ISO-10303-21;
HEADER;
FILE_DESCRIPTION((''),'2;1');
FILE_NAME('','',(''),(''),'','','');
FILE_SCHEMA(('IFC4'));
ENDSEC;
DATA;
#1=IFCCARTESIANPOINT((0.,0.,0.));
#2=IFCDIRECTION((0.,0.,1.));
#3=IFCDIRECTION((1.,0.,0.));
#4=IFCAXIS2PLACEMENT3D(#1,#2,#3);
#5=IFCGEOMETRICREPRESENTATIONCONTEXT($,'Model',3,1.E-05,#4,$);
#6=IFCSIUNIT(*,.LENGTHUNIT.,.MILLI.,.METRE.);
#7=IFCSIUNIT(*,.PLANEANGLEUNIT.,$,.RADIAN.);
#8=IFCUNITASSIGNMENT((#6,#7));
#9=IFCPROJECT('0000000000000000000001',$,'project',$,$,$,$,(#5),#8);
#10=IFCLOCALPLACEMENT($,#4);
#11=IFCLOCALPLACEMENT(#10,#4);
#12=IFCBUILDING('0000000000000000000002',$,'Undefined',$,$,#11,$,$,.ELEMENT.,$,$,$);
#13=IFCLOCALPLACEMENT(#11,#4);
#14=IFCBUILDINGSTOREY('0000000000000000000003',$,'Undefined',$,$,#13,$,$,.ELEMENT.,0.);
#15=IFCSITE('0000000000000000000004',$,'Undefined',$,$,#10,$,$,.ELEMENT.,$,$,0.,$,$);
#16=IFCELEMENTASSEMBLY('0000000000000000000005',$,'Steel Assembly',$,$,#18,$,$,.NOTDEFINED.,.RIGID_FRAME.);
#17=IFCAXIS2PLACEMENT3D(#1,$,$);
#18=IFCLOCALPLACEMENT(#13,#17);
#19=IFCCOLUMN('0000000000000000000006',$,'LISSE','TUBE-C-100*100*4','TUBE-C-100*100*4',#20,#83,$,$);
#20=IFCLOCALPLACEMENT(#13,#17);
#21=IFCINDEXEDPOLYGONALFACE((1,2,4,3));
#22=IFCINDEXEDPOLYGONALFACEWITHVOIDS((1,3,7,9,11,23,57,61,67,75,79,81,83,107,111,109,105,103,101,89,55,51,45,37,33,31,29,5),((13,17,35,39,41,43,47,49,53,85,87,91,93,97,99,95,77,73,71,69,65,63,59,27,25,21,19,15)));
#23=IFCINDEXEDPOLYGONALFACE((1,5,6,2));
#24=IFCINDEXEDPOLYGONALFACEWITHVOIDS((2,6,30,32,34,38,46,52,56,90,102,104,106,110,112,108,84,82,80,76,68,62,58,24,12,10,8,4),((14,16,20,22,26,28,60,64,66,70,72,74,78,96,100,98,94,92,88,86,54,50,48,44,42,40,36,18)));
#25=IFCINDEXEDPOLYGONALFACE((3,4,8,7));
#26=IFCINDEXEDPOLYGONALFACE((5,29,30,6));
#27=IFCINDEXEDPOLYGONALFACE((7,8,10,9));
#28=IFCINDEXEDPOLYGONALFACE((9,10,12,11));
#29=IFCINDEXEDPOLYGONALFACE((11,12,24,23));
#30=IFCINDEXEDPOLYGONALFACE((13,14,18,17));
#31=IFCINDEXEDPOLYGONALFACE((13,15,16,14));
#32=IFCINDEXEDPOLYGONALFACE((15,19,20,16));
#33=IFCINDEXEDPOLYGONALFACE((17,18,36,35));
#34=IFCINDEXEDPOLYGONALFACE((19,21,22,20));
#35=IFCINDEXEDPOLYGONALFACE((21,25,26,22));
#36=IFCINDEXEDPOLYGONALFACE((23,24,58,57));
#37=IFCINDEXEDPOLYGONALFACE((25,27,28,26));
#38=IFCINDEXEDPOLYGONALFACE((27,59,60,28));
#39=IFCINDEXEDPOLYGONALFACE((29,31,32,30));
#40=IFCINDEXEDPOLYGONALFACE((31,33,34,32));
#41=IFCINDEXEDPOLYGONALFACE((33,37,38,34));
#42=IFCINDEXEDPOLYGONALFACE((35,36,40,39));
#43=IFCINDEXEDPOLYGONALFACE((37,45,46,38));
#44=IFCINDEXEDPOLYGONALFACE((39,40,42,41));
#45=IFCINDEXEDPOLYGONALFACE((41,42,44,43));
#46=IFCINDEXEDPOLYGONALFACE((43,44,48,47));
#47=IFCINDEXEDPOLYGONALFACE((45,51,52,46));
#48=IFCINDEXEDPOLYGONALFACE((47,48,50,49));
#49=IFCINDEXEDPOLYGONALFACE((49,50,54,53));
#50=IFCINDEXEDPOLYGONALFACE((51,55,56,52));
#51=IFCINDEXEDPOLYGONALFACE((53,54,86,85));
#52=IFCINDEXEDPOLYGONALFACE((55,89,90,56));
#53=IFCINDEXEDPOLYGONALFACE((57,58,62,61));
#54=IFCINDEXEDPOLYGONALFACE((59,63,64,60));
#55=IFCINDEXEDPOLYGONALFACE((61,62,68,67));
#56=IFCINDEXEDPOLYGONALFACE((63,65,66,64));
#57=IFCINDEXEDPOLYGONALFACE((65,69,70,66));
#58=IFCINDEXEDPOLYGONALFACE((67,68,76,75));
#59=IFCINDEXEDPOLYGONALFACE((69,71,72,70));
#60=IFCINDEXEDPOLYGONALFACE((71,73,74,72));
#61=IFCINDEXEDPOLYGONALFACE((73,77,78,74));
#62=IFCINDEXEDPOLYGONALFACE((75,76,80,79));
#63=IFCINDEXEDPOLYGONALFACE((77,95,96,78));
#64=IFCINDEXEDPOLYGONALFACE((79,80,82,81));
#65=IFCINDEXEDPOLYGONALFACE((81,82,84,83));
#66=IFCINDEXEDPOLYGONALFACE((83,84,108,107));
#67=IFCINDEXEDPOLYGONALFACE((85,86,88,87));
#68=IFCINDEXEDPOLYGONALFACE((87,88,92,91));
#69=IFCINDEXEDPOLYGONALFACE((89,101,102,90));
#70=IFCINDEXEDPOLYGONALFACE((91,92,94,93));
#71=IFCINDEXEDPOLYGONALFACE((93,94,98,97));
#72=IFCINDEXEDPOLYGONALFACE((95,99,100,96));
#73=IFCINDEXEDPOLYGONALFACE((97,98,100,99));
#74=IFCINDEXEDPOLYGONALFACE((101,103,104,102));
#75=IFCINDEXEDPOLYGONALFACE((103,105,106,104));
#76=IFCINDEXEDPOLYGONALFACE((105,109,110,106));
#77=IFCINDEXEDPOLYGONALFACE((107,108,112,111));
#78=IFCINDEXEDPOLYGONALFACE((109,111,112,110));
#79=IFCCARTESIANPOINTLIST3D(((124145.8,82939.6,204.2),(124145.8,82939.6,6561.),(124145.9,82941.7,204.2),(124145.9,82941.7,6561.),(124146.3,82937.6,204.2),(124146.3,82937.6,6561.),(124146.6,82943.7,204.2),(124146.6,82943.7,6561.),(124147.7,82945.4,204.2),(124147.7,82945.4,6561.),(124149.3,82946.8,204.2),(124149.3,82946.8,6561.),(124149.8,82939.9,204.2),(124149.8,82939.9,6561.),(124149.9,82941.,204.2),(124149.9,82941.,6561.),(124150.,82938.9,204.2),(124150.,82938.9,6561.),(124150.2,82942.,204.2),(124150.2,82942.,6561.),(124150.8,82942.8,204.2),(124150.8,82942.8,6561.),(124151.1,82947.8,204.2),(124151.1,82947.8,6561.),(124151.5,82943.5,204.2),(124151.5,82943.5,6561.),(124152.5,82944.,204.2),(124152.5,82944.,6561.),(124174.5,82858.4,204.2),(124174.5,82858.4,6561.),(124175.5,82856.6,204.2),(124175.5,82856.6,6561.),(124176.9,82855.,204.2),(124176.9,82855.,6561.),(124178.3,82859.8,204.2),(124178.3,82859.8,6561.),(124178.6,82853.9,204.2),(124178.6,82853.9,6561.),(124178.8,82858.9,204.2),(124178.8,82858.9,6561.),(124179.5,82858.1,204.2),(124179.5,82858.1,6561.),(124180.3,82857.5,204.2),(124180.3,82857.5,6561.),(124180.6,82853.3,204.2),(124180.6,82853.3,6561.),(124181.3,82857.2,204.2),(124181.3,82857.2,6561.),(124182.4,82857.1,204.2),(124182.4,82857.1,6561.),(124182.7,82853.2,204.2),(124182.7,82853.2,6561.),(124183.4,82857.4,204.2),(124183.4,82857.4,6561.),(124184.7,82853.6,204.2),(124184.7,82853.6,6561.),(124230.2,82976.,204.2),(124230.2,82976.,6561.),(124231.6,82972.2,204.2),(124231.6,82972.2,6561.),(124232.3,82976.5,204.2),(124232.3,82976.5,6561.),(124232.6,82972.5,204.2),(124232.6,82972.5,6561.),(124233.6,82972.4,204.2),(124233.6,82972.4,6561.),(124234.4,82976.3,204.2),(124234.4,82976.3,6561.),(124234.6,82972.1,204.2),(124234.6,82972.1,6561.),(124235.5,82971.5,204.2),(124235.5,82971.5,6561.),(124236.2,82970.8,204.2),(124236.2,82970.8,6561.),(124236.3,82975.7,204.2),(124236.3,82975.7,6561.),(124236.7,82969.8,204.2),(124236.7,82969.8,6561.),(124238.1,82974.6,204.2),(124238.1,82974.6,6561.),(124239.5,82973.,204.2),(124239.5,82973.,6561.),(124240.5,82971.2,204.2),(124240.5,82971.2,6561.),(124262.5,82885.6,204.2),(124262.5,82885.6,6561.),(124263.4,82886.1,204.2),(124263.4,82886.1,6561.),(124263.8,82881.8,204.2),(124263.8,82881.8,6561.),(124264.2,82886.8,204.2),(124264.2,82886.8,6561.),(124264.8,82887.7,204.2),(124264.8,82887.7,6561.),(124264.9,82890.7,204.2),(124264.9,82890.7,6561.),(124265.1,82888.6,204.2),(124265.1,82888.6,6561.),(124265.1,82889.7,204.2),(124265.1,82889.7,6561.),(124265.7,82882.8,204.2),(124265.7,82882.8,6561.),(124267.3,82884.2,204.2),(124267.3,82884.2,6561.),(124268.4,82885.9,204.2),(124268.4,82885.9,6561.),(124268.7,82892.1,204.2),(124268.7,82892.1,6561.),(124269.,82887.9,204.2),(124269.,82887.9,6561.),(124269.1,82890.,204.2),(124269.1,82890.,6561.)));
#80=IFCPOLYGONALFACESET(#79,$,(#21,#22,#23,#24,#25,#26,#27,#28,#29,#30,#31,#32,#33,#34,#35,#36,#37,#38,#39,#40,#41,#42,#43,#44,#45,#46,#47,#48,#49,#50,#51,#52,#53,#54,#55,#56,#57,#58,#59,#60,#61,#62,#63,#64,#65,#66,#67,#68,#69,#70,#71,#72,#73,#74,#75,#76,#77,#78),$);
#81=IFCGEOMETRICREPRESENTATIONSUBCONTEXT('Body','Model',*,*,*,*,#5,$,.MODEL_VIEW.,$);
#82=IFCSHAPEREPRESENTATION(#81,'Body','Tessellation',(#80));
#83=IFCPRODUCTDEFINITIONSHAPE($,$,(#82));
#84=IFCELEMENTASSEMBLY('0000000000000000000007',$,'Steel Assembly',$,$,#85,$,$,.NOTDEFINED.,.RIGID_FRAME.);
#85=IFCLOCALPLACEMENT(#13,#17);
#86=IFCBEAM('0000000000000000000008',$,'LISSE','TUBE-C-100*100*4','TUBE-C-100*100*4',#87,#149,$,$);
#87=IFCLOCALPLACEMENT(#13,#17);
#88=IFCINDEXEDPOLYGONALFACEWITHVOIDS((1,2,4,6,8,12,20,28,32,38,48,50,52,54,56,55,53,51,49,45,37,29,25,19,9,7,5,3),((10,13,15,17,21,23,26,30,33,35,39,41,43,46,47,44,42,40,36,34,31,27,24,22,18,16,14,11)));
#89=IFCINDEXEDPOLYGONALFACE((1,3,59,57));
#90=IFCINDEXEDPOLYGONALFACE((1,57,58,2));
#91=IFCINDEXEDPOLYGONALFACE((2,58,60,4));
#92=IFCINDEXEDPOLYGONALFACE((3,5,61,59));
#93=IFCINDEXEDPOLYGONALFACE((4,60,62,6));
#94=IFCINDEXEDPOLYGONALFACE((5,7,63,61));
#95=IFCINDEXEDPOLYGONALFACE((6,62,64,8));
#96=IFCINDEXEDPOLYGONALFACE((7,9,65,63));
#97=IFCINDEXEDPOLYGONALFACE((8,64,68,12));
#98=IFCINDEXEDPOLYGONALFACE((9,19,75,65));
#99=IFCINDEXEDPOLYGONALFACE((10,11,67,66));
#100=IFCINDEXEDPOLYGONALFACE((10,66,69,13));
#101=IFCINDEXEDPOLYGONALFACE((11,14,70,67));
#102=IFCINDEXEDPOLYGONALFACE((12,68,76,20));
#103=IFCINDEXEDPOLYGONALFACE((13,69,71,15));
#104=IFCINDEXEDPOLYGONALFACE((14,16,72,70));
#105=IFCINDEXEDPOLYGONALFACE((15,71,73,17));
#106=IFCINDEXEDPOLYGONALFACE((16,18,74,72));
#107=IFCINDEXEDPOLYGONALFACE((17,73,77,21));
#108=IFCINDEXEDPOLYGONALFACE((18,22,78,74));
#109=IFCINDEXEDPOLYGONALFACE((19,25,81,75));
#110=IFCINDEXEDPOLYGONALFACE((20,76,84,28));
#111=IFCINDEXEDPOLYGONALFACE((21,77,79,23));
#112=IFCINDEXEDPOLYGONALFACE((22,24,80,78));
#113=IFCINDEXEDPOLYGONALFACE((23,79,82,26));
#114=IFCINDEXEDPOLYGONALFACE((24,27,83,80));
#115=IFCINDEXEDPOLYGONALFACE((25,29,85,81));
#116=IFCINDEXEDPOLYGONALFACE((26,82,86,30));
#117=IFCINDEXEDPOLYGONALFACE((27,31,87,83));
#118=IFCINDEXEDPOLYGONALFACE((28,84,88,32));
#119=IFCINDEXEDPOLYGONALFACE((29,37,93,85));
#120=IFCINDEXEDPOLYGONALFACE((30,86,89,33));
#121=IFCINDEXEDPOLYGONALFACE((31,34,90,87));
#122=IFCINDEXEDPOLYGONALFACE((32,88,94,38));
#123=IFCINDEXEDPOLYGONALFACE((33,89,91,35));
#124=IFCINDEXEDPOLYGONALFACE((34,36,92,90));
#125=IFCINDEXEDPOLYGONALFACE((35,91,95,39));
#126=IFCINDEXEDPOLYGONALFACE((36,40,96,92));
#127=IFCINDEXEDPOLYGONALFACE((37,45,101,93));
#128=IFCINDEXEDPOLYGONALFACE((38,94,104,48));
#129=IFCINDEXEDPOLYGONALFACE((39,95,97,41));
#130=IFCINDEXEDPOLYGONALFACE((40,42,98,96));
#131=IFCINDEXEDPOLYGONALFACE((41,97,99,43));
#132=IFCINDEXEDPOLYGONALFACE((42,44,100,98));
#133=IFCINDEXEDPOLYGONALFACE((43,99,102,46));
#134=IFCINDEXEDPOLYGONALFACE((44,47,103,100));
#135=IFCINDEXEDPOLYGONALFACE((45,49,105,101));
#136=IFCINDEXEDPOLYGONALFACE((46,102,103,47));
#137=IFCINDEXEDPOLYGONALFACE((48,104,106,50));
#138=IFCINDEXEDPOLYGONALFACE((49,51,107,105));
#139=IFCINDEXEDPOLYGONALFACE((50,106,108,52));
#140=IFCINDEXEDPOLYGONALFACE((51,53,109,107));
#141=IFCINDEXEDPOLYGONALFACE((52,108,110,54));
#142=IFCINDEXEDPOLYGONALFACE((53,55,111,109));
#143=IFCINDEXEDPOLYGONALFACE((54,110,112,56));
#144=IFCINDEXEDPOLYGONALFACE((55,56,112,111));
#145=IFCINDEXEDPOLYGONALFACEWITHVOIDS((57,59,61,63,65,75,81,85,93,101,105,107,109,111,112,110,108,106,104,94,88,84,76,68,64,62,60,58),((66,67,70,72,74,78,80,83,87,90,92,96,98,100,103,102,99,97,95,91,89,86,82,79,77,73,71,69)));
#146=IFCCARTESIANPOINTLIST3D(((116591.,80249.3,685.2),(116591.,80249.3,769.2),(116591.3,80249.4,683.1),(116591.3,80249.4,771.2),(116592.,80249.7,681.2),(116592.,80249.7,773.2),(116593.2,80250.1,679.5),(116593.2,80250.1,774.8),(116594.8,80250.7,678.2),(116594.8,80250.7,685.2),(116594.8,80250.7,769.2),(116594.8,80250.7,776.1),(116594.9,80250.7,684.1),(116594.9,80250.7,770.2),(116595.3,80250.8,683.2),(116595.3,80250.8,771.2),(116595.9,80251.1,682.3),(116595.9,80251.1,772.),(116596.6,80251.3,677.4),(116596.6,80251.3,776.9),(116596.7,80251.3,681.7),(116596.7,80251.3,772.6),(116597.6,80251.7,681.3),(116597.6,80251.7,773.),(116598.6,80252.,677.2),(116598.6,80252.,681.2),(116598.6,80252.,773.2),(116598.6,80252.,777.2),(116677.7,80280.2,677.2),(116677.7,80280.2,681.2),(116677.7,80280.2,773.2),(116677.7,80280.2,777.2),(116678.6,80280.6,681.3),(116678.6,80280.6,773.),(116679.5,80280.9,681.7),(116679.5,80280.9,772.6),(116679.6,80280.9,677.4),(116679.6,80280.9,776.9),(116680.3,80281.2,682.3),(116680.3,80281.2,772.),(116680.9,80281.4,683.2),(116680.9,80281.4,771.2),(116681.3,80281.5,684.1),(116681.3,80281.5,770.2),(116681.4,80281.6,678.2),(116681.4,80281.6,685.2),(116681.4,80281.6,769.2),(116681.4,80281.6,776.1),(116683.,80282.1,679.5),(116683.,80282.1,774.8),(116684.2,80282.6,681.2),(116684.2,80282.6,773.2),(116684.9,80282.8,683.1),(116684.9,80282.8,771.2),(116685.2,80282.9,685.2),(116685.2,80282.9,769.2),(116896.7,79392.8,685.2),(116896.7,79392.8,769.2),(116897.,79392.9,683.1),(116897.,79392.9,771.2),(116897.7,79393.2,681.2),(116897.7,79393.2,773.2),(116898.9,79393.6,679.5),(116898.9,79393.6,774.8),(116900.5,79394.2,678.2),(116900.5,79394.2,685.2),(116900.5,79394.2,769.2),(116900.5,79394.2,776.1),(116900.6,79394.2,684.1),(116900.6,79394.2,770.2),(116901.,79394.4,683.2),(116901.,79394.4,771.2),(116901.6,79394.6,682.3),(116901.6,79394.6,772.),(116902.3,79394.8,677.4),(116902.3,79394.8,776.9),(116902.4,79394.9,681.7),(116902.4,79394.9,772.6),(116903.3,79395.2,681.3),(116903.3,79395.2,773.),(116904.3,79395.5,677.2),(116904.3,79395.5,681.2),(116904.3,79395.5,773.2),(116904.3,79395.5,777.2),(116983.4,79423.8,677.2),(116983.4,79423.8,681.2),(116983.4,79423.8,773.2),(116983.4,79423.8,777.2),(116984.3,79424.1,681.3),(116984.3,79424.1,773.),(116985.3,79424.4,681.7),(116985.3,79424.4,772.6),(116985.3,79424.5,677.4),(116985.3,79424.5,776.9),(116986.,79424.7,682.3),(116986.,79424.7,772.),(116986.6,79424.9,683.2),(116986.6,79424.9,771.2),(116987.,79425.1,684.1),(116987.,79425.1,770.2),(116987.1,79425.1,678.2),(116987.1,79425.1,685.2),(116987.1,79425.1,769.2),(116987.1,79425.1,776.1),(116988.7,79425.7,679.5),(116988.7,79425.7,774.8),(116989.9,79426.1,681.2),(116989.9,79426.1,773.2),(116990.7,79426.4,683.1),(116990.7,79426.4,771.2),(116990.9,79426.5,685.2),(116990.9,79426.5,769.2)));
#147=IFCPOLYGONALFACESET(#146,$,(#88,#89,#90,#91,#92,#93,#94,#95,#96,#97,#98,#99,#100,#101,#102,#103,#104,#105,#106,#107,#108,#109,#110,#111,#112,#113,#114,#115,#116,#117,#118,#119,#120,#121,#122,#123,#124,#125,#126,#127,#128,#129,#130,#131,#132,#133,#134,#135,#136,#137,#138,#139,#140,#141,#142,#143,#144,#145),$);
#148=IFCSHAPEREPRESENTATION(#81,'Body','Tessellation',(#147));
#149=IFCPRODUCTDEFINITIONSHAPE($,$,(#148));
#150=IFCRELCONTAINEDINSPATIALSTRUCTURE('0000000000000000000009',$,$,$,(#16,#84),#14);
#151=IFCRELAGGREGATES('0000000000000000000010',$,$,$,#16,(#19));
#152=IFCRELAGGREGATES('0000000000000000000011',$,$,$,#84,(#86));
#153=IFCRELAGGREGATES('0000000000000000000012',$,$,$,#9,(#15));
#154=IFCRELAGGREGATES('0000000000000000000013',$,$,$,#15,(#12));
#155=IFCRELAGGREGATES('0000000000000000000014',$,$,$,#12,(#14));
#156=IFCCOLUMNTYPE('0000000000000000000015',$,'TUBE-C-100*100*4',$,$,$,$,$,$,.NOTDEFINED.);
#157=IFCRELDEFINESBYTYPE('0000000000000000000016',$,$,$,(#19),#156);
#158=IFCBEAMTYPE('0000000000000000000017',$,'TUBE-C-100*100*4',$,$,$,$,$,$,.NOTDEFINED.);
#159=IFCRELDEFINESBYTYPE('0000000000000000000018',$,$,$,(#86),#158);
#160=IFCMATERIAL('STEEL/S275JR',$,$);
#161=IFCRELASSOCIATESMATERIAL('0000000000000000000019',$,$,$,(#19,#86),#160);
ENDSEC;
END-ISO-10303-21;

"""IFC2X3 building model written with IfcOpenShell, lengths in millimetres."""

from ifc_helpers import new_model, si_unit, frame, origin_with_axes, origin_2d_with_axis, place, context, subcontext, project, spatial, hollow_rectangle, extrude, material, type_object, element, aggregate, save


model = new_model("IFC2X3")

# Units and contexts
model_context = context("Model", 3, precision=1e-05, world=origin_with_axes())
body_context = subcontext(model_context, "Body", "Model", "MODEL_VIEW")
ifc_project = project(units=[si_unit("LENGTHUNIT", "METRE", prefix="MILLI"), si_unit("PLANEANGLEUNIT", "RADIAN")], contexts=[model_context])

# Site, building, storey
site_placement = place(None, origin_with_axes())
site = spatial("IfcSite", under=ifc_project, at=site_placement, Name="Undefined", CompositionType="ELEMENT", RefElevation=0.0)
building_placement = place(site_placement, origin_with_axes())
building = spatial("IfcBuilding", under=site, at=building_placement, Name="Undefined", CompositionType="ELEMENT")
storey_placement = place(building_placement, origin_with_axes())
storey = spatial("IfcBuildingStorey", under=building, at=storey_placement, Name="Undefined", CompositionType="ELEMENT", Elevation=0.0)

# Element assembly, column
assembly_1_placement = place(storey_placement, origin_with_axes())
assembly_1 = element("IfcElementAssembly", 1, at=assembly_1_placement, inside=storey, Name="Steel Assembly", AssemblyPlace="NOTDEFINED", PredefinedType="RIGID_FRAME")
ifc_material = material(Name="STEEL/S275JR")
column_type = type_object("IfcColumnType", Name="TUBE-C-100*100*4", PredefinedType="NOTDEFINED")
column_placement = place(assembly_1_placement, frame((124207.5, 82914.8, 6561.0), z_axis=(0.0, 0.0, -1.0), x_axis=(0.941802, 0.336168, 0.0)))
column = element("IfcColumn", 2, at=column_placement, type_object=column_type, material=ifc_material, Name="LISSE", Description="TUBE-C-100*100*4", ObjectType="TUBE-C-100*100*4", context=body_context, shape_type="SweptSolid", body=[
    extrude(hollow_rectangle(XDim=100.0, YDim=100.0, WallThickness=4.0, InnerFilletRadius=4.0, OuterFilletRadius=8.0, at=origin_2d_with_axis()), frame((0.0, 0.0, 6356.8), z_axis=(0.0, 0.0, -1.0), x_axis=(0.0, 1.0, 0.0)), (0.0, 0.0, 1.0), 6356.8),
])
aggregate(assembly_1, [column])

# Element assembly, beam
assembly_2_placement = place(storey_placement, origin_with_axes())
assembly_2 = element("IfcElementAssembly", 3, at=assembly_2_placement, inside=storey, Name="Steel Assembly", AssemblyPlace="NOTDEFINED", PredefinedType="RIGID_FRAME")
beam_type_1 = type_object("IfcBeamType", Name="TUBE-C-100*100*4", PredefinedType="NOTDEFINED")
beam_1_placement = place(assembly_2_placement, frame((116943.8, 79409.6, 727.2), z_axis=(0.941802, 0.336168, 0.0), x_axis=(-0.336168, 0.941802, 0.0)))
beam_1 = element("IfcBeam", 4, at=beam_1_placement, type_object=beam_type_1, material=ifc_material, Name="LISSE", Description="TUBE-C-100*100*4", ObjectType="TUBE-C-100*100*4", context=body_context, shape_type="SweptSolid", body=[
    extrude(hollow_rectangle(XDim=100.0, YDim=100.0, WallThickness=4.0, InnerFilletRadius=4.0, OuterFilletRadius=8.0, at=origin_2d_with_axis()), frame((909.4, 0.0, 0.0), z_axis=(-1.0, 0.0, 0.0), x_axis=(0.0, -1.0, 0.0)), (0.0, 0.0, 1.0), 909.4),
])
aggregate(assembly_2, [beam_1])

save(model, "model.ifc")
